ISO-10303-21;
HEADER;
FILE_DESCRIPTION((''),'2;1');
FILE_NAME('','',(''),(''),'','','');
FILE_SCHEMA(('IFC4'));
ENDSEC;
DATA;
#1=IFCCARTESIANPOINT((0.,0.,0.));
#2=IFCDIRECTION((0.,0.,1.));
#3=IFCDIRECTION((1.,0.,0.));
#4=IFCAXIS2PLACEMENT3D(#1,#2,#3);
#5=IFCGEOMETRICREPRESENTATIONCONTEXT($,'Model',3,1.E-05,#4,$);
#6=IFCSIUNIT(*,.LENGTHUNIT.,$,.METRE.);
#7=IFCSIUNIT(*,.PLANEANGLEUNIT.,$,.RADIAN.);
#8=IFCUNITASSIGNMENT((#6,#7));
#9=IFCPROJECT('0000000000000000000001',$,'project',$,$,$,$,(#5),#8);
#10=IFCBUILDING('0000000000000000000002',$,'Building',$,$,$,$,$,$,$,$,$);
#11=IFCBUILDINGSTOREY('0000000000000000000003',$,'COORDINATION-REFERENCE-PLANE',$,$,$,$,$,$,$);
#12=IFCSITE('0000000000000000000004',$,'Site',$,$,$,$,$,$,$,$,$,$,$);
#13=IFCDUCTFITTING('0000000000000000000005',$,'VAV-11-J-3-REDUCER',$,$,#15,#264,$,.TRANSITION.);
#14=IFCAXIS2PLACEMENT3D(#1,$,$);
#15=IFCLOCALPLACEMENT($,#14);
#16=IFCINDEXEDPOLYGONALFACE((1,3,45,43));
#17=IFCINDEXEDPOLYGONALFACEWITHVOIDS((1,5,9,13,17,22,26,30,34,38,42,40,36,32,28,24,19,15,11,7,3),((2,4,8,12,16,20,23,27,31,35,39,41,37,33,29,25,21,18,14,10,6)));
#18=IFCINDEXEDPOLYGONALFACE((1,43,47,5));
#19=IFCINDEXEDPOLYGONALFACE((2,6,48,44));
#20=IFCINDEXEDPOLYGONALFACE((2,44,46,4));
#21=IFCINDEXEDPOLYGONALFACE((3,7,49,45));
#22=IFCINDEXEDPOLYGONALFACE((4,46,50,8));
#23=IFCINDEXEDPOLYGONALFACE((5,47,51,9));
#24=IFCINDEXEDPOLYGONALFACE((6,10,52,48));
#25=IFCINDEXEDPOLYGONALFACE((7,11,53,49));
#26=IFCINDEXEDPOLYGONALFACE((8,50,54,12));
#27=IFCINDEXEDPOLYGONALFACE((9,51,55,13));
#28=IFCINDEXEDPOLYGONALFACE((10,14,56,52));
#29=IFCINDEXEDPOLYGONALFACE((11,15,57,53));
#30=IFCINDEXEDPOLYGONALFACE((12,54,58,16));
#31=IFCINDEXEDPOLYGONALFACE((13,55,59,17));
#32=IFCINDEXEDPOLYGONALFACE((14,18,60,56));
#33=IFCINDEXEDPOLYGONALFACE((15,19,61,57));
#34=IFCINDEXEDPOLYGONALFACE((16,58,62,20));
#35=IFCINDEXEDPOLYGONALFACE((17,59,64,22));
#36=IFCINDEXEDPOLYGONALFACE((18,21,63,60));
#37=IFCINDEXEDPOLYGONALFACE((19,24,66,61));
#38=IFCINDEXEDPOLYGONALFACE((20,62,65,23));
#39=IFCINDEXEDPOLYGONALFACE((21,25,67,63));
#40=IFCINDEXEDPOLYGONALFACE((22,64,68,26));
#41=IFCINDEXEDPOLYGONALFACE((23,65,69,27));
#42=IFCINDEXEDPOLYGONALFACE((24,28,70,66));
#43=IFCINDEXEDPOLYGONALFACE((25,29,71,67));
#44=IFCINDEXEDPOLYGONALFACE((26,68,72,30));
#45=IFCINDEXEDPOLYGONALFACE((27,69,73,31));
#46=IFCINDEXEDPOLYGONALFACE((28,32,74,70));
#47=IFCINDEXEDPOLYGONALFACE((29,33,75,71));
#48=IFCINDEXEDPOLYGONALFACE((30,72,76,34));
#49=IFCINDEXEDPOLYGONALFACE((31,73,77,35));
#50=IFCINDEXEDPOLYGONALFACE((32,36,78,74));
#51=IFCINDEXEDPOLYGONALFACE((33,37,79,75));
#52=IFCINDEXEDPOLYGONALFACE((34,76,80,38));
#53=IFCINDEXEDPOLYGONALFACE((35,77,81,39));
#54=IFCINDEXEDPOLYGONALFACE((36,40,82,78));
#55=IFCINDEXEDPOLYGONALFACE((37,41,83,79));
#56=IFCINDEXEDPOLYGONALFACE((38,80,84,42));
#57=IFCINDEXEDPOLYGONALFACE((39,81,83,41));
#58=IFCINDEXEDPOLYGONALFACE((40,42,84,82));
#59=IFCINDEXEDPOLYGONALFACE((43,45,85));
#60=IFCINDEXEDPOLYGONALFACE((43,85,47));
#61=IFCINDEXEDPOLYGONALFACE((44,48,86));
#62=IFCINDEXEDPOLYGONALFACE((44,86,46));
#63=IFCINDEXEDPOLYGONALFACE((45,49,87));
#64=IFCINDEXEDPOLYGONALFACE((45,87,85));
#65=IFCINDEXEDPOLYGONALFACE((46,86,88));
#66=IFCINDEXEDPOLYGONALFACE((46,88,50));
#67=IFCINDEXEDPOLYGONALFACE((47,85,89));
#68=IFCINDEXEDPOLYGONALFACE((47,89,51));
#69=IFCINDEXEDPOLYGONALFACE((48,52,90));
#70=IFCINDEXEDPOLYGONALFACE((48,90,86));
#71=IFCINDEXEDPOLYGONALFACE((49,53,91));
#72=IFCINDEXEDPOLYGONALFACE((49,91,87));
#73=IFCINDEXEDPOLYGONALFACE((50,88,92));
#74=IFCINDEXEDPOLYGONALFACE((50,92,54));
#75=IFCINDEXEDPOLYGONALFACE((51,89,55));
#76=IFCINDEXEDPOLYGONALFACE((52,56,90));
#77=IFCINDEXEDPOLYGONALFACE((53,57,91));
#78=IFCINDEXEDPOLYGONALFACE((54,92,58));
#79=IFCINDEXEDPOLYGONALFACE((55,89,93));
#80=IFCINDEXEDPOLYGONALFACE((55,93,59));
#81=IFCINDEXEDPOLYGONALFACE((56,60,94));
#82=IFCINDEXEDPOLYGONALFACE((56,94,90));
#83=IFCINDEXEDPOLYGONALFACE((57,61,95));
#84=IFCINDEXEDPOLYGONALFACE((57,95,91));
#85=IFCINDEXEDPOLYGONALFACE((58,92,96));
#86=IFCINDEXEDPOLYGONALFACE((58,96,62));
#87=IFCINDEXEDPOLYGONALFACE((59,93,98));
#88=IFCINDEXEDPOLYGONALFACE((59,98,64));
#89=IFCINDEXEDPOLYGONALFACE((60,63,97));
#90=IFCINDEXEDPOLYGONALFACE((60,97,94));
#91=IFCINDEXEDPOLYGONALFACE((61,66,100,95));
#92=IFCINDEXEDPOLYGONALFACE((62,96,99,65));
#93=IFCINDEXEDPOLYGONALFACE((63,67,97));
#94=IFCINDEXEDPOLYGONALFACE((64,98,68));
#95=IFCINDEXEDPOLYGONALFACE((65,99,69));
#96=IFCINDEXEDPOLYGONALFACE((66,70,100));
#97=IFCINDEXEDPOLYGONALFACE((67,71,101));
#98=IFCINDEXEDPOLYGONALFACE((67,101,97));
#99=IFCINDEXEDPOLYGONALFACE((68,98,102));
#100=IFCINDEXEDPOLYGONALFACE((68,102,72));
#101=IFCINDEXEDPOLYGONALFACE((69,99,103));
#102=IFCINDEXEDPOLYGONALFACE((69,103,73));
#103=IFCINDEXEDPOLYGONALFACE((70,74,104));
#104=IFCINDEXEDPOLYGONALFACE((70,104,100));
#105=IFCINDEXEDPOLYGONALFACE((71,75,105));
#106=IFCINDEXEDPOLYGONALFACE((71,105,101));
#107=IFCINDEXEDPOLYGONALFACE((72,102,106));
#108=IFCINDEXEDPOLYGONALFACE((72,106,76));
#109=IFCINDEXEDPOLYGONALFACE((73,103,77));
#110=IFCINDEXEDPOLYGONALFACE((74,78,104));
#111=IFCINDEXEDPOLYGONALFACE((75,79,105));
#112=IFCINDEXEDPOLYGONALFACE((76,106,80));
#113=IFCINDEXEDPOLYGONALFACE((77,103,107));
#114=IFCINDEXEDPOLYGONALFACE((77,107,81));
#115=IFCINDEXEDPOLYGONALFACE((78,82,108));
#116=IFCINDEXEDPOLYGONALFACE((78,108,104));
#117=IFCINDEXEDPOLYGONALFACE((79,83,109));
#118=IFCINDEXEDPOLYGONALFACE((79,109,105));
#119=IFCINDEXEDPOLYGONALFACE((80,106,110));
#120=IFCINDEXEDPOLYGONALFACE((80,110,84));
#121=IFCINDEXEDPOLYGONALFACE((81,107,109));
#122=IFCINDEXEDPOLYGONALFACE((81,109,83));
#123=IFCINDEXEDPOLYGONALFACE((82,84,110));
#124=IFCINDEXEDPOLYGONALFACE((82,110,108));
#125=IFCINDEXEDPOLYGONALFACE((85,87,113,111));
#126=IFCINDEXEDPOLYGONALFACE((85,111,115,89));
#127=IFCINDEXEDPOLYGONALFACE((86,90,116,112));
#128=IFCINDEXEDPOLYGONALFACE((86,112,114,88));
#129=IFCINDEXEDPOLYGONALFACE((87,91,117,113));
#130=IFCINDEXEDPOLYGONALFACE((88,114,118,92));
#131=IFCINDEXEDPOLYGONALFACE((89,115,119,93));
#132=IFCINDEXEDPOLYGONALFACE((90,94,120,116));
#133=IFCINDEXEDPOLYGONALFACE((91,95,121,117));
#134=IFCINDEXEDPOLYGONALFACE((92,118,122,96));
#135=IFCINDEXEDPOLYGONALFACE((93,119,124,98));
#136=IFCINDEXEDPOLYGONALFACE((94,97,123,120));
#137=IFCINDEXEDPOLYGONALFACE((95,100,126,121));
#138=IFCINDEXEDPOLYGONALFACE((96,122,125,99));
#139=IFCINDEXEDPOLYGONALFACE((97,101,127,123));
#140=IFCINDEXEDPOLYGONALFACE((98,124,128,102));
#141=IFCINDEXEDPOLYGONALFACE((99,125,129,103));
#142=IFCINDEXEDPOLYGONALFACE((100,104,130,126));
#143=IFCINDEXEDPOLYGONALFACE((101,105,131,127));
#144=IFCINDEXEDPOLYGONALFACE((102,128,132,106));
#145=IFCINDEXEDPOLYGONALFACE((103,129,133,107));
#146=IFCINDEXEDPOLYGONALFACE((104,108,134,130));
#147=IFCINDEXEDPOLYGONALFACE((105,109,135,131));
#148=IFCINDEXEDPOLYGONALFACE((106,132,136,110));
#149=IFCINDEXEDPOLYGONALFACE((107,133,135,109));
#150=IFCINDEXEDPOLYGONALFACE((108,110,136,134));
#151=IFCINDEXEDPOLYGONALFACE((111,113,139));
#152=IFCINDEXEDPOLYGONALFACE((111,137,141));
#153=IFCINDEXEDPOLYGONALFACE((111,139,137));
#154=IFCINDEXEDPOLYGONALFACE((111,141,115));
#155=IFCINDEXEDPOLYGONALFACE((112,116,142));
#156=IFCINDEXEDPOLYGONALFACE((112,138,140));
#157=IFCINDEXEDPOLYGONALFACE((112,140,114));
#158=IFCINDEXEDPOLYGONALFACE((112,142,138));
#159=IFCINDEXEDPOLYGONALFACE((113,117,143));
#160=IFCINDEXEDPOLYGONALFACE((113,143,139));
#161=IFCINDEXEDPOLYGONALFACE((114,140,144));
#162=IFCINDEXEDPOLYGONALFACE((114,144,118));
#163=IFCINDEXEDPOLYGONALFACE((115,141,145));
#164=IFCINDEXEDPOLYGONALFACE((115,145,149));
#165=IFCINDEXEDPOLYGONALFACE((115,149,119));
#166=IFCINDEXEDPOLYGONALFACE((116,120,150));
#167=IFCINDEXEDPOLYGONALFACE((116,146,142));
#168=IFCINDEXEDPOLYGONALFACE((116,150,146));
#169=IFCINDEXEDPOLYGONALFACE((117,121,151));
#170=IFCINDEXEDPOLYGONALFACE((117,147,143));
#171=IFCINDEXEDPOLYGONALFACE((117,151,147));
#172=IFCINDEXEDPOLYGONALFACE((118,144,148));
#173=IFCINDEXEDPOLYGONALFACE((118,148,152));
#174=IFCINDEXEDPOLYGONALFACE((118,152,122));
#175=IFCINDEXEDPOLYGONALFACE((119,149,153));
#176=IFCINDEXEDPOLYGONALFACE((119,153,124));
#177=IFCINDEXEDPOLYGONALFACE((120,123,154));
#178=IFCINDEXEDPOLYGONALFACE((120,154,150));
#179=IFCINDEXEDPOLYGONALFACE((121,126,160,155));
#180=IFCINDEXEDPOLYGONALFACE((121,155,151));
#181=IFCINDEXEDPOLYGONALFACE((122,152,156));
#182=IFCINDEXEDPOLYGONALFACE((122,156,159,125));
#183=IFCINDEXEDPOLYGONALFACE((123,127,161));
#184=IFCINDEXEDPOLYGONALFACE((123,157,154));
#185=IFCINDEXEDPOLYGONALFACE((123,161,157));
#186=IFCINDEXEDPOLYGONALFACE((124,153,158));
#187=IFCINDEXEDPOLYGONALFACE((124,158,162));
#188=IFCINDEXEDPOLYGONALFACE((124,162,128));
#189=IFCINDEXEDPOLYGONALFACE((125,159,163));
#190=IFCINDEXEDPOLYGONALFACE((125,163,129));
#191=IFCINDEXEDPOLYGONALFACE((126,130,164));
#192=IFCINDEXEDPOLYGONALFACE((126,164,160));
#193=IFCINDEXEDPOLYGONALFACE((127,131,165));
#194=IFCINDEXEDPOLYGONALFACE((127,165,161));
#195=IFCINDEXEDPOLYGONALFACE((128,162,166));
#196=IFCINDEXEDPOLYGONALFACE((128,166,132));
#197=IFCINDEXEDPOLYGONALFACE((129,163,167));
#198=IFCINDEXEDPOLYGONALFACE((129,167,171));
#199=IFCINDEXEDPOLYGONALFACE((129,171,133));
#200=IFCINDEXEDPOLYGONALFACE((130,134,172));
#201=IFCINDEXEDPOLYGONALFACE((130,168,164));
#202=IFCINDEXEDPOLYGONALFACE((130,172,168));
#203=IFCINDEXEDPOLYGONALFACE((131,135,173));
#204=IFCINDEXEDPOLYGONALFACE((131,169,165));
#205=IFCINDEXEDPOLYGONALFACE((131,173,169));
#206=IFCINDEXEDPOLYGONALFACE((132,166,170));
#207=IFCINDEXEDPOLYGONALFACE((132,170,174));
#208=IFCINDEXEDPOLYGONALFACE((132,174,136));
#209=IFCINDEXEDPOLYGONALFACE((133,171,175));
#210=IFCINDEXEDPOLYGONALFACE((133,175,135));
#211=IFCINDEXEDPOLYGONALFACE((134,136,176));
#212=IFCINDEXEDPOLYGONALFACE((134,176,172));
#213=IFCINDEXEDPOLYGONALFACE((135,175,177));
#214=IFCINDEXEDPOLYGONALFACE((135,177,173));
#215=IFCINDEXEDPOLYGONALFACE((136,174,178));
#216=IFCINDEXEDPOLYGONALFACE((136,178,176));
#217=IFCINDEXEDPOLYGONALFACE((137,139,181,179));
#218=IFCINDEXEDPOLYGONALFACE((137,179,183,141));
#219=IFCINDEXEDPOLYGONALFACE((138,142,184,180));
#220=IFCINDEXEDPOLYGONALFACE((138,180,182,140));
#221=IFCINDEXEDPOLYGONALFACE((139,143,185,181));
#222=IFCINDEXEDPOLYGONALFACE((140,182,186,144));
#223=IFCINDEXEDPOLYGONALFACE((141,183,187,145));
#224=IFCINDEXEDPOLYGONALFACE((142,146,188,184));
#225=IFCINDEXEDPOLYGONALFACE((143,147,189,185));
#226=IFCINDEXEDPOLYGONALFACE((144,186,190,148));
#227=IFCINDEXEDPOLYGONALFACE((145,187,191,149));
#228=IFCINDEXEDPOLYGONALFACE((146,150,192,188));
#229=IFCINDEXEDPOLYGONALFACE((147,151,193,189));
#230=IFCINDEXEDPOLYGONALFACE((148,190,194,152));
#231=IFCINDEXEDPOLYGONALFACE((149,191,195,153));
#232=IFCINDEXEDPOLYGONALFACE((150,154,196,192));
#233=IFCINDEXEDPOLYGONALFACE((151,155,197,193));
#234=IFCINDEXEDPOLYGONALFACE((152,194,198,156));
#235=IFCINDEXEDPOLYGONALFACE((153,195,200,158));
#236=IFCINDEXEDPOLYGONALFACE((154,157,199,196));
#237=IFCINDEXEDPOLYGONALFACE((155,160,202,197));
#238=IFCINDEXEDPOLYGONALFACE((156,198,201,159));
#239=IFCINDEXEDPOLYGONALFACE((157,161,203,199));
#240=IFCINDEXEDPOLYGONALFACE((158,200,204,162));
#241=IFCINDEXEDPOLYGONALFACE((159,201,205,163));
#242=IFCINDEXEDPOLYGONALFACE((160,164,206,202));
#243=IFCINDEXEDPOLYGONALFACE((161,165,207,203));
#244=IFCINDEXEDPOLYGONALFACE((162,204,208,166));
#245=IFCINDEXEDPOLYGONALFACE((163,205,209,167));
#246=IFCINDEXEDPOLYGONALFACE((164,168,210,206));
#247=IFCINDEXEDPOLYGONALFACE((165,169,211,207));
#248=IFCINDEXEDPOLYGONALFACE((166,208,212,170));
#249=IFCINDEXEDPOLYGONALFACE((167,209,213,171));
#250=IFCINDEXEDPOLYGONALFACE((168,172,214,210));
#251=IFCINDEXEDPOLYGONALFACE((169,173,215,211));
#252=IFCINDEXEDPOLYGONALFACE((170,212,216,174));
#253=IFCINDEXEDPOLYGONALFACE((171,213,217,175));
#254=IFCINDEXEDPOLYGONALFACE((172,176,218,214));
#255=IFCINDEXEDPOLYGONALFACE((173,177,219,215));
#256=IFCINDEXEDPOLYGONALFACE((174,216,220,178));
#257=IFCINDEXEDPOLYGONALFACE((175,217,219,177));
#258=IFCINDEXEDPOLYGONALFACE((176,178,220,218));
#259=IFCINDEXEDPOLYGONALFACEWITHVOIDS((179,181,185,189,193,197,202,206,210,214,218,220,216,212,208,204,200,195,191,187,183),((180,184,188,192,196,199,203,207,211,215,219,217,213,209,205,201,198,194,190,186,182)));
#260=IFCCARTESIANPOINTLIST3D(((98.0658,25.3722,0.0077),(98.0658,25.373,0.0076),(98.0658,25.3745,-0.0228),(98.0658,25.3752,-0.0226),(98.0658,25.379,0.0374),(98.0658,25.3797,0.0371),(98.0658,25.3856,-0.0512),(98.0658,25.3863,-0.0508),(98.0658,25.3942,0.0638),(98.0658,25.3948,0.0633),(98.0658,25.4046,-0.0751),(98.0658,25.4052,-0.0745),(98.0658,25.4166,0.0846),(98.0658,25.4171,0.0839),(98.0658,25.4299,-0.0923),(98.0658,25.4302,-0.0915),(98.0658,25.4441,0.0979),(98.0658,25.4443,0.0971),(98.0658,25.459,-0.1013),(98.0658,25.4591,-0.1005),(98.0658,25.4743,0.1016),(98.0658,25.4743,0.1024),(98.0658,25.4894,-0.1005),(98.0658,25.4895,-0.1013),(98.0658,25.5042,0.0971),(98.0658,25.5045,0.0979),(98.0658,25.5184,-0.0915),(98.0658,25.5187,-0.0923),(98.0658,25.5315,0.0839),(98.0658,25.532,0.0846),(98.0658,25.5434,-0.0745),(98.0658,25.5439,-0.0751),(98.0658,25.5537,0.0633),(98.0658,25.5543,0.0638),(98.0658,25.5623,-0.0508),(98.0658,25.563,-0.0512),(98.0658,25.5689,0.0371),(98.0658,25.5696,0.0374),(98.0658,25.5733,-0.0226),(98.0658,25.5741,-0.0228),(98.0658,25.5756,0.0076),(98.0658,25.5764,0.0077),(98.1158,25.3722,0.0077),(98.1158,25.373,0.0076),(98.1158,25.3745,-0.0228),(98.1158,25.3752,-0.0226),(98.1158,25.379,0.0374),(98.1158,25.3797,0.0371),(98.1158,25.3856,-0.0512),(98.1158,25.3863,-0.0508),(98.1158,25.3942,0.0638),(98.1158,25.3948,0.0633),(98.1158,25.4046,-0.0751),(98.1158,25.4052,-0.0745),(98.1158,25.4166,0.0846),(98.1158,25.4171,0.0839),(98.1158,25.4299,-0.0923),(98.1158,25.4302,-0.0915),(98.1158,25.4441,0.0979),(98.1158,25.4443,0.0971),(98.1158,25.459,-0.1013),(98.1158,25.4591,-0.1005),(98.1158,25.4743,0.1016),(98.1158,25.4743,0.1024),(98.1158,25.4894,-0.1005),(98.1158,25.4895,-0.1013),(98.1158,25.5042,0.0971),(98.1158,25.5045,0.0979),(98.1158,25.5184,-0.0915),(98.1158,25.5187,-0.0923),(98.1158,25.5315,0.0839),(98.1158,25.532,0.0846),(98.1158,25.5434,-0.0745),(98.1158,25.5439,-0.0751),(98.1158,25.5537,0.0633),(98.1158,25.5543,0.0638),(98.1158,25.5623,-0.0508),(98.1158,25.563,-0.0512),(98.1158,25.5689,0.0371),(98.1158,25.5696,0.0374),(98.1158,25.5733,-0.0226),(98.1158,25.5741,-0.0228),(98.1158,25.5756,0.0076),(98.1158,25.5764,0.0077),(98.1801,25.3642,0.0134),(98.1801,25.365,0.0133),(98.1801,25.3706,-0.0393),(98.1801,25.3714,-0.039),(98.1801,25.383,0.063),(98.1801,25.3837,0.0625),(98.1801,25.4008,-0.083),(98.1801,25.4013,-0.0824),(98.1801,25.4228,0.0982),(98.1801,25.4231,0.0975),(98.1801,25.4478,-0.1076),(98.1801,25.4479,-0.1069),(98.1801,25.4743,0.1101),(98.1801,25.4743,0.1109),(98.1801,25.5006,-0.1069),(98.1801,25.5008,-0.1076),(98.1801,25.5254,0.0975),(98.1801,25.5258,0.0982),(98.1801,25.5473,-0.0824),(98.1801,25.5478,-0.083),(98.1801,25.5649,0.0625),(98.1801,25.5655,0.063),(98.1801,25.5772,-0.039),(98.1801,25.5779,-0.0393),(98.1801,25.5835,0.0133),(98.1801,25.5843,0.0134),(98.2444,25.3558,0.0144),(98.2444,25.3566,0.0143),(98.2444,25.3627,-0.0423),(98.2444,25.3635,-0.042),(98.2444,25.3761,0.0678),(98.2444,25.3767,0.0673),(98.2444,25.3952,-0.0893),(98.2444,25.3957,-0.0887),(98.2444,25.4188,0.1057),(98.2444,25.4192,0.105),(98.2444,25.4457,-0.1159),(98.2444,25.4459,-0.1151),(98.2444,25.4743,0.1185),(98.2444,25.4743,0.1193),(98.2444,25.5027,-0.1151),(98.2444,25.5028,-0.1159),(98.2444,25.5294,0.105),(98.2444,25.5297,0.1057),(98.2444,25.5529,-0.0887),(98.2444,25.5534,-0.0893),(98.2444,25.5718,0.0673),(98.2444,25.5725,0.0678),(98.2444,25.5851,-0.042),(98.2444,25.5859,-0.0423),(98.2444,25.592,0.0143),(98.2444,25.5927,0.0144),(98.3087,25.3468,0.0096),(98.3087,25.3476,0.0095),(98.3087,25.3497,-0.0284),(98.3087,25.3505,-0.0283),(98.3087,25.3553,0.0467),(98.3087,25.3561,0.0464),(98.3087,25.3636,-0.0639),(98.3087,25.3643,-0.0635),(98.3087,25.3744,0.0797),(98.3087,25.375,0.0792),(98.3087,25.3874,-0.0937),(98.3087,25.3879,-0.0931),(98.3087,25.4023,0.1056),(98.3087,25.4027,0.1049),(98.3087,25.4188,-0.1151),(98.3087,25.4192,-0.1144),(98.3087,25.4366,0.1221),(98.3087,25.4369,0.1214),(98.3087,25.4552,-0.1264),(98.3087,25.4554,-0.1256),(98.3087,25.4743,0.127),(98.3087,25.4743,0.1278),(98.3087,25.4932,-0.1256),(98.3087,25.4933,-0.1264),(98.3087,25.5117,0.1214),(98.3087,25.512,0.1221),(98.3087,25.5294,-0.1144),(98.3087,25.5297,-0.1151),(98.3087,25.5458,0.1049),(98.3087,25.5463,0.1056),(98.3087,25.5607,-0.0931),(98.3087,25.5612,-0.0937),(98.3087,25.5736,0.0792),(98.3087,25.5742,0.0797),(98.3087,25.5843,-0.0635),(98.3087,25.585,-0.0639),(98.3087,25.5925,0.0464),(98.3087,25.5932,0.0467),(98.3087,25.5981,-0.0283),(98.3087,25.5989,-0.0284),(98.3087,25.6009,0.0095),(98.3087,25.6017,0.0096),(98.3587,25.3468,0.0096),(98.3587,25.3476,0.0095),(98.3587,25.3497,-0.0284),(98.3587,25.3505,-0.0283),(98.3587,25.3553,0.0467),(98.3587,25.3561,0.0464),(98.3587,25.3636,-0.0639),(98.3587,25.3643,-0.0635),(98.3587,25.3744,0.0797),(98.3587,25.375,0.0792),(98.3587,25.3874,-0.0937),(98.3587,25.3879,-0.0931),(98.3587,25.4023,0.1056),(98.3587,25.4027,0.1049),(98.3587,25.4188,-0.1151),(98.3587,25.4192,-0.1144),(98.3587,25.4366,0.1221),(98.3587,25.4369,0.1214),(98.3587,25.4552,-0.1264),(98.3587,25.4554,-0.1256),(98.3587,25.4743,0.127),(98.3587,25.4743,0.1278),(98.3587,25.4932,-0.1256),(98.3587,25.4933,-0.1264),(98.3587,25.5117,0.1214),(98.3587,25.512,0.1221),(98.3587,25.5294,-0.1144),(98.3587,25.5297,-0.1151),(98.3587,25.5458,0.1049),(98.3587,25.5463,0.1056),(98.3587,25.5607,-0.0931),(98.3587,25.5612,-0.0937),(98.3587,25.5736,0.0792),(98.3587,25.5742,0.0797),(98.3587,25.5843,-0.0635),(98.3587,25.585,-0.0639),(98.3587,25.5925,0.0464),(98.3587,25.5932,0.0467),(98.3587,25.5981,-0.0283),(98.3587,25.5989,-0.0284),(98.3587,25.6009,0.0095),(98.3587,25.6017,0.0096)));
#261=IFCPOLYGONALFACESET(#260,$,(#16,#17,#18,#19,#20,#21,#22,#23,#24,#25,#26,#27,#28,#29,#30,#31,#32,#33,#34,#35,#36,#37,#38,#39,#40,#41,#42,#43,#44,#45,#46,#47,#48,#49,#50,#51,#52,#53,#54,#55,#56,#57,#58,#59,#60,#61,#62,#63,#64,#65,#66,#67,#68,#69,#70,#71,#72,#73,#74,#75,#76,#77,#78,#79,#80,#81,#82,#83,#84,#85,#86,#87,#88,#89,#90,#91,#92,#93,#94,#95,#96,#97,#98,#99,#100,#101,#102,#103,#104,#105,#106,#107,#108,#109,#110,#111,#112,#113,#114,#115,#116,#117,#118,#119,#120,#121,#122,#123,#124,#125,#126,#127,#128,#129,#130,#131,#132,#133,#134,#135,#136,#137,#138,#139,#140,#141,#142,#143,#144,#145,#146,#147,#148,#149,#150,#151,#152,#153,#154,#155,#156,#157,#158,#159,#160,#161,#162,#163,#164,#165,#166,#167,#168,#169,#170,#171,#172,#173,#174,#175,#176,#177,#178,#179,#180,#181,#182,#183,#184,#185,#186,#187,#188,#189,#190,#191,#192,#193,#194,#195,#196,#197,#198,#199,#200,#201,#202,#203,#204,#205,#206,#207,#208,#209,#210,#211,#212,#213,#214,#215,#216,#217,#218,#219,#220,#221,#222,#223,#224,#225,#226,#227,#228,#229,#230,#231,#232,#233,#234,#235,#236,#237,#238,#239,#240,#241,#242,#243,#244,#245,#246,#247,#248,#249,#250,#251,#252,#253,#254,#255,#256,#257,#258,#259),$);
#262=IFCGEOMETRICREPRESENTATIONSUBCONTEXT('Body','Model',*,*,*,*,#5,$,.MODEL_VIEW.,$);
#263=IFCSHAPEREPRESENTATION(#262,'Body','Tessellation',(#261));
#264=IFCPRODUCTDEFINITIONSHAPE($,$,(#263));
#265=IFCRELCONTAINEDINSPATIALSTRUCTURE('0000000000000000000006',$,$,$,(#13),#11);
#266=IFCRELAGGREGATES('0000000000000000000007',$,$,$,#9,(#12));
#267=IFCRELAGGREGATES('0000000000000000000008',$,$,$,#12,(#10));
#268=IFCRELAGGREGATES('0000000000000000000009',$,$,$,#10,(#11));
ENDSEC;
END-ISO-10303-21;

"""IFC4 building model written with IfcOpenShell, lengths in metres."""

from ifc_helpers import new_model, entity, si_unit, frame, origin_with_axes, place, context, subcontext, project, spatial, element, save


model = new_model("IFC4")

# Units and contexts
model_context = context("Model", 3, precision=1e-05, world=origin_with_axes())
body_context_1 = subcontext(model_context, "Body", "Model", "MODEL_VIEW")
ifc_project = project(units=[si_unit("LENGTHUNIT", "METRE"), si_unit("PLANEANGLEUNIT", "RADIAN")], contexts=[model_context])

# Site, building, storey
site = spatial("IfcSite", under=ifc_project, Name="Site")
building = spatial("IfcBuilding", under=site, Name="Building")
storey = spatial("IfcBuildingStorey", under=building, Name="COORDINATION-REFERENCE-PLANE")

# Duct fitting
for number, where, z_axis, x_axis, name in (
    (1, (98.3587, 25.4743, 0.0), (0.0, -1.0, 0.0), (0.0, 0.0, 1.0), "VAV-11-J-3-REDUCER"),
):
    element("IfcDuctFitting", number, at=place(None, frame(where, z_axis=z_axis, x_axis=x_axis)), inside=storey, Name=name, PredefinedType="TRANSITION", context=body_context_1, shape_type="SweptSolid", body=[
        entity("IfcRevolvedAreaSolid", entity("IfcArbitraryClosedProfileDef", "AREA", None, entity("IfcPolyline", [entity("IfcCartesianPoint", [0.1278, 0.0]), entity("IfcCartesianPoint", [0.1278, 0.05]), entity("IfcCartesianPoint", [0.1024, 0.2429]), entity("IfcCartesianPoint", [0.1024, 0.2929]), entity("IfcCartesianPoint", [0.1016, 0.2929]), entity("IfcCartesianPoint", [0.1016, 0.2429]), entity("IfcCartesianPoint", [0.127, 0.05]), entity("IfcCartesianPoint", [0.127, 0.0]), entity("IfcCartesianPoint", [0.1278, 0.0])])), entity("IfcAxis2Placement3D", entity("IfcCartesianPoint", [0.0, 0.0, 0.0])), entity("IfcAxis1Placement", entity("IfcCartesianPoint", [0.0, 0.0, 0.0]), entity("IfcDirection", [0.0, 1.0, 0.0])), 6.283185),
    ])

save(model, "model.ifc")
